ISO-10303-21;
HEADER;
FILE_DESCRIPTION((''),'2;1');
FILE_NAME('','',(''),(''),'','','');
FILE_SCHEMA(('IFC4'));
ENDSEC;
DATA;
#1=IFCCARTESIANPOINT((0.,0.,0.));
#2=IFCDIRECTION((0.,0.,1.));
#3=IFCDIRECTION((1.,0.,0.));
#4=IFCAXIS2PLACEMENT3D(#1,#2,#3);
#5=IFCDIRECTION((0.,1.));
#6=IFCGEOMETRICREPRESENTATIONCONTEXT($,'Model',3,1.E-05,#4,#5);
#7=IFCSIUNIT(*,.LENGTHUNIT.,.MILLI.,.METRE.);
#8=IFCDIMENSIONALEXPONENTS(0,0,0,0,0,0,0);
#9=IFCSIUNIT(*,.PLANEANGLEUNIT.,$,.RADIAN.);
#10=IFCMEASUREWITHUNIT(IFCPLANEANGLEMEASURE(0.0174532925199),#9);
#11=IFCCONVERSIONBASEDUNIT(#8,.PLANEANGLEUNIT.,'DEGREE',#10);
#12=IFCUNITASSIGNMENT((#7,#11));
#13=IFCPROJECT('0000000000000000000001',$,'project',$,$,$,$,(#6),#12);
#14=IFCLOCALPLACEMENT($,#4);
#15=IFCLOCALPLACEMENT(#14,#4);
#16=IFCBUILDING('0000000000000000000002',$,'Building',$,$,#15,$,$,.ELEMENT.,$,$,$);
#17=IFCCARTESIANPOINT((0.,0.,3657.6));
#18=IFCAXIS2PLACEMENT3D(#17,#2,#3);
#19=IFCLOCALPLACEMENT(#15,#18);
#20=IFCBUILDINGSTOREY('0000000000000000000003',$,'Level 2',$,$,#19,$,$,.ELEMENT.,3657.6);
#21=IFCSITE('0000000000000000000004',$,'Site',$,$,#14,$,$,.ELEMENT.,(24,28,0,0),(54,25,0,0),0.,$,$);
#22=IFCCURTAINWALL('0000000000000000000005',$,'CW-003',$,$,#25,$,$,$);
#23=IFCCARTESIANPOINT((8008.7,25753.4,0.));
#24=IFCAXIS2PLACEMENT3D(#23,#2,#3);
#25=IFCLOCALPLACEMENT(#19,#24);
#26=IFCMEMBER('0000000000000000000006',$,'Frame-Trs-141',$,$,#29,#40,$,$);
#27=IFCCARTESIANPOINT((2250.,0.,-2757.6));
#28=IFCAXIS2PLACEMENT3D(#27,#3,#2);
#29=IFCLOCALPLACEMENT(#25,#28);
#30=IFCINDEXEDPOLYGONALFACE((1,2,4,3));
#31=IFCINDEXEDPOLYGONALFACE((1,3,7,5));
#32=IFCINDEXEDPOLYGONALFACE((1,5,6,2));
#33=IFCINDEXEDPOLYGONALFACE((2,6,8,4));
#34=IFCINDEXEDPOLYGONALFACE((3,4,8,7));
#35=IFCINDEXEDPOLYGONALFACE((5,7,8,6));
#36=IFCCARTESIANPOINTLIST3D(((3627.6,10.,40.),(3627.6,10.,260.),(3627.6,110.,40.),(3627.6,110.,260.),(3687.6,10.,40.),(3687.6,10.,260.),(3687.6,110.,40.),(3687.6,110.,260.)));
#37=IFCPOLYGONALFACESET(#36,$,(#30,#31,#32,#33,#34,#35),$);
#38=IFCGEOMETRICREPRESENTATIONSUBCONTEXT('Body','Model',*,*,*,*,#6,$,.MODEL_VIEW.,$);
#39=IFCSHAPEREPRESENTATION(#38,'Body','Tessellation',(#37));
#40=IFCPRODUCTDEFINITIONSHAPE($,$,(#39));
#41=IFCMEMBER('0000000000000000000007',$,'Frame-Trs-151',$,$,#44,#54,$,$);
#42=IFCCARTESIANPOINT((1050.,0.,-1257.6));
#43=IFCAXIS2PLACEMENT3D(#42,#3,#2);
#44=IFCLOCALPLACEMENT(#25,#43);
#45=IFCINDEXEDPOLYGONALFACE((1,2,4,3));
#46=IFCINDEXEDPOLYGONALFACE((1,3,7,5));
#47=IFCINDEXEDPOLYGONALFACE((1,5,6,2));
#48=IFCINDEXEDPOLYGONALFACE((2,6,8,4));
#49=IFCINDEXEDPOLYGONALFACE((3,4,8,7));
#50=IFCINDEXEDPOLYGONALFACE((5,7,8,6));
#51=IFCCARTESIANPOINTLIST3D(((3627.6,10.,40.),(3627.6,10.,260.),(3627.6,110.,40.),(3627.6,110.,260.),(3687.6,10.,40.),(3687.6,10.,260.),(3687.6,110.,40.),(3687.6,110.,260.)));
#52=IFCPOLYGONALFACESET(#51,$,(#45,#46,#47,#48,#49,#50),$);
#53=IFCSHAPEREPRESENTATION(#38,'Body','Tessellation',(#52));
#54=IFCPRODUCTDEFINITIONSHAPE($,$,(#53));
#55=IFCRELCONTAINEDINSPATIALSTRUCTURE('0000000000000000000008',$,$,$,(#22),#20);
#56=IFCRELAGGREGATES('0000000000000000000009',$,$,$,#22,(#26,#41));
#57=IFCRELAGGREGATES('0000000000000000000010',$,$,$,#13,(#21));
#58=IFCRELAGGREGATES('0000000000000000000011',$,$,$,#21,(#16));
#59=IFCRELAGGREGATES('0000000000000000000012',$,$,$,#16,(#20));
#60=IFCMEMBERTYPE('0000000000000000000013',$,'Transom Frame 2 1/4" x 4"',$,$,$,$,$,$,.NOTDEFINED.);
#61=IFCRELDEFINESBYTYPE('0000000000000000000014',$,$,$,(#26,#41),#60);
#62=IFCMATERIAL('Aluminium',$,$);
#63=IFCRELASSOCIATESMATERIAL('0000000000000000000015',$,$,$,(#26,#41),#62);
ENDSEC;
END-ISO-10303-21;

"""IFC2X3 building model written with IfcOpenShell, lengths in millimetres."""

from ifc_helpers import new_model, entity, si_unit, converted_unit, direction, frame, origin_with_axes, place, context, subcontext, project, spatial, polyline, outline, extrude, material, type_object, element, aggregate, save


model = new_model("IFC2X3")

# Units and contexts
model_context = context("Model", 3, precision=1e-05, world=origin_with_axes(), true_north=direction((0.0, 1.0)))
body_context = subcontext(model_context, "Body", "Model", "MODEL_VIEW")
ifc_project = project(units=[si_unit("LENGTHUNIT", "METRE", prefix="MILLI"), converted_unit("PLANEANGLEUNIT", "DEGREE", entity("IfcPlaneAngleMeasure", 0.0174532925199), si_unit("PLANEANGLEUNIT", "RADIAN"), dimensions=[0, 0, 0, 0, 0, 0, 0])], contexts=[model_context])

# Site, building, storey
site_placement = place(None, origin_with_axes())
site = spatial("IfcSite", under=ifc_project, at=site_placement, Name="Site", CompositionType="ELEMENT", RefLatitude=(24, 28, 0, 0), RefLongitude=(54, 25, 0, 0), RefElevation=0.0)
building_placement = place(site_placement, origin_with_axes())
building = spatial("IfcBuilding", under=site, at=building_placement, Name="Building", CompositionType="ELEMENT")
storey_placement = place(building_placement, frame((0.0, 0.0, 3657.6), z_axis=(0.0, 0.0, 1.0), x_axis=(1.0, 0.0, 0.0)))
storey = spatial("IfcBuildingStorey", under=building, at=storey_placement, Name="Level 2", CompositionType="ELEMENT", Elevation=3657.6)

# Curtain wall, members
curtain_wall_placement = place(storey_placement, frame((8008.7, 25753.4, 0.0), z_axis=(0.0, 0.0, 1.0), x_axis=(1.0, 0.0, 0.0)))
curtain_wall = element("IfcCurtainWall", 1, at=curtain_wall_placement, inside=storey, Name="CW-003")
ifc_material_1 = material(Name="Aluminium")
member_type_1 = type_object("IfcMemberType", Name="Transom Frame 2 1/4\" x 4\"", PredefinedType="NOTDEFINED")
member_1_placement = place(curtain_wall_placement, frame((2250.0, 0.0, -2757.6), z_axis=(1.0, 0.0, 0.0), x_axis=(0.0, 0.0, 1.0)))
member_1 = element("IfcMember", 2, at=member_1_placement, type_object=member_type_1, material=ifc_material_1, Name="Frame-Trs-141", context=body_context, shape_type="SweptSolid", body=[
    extrude(outline(polyline([(110.0, -3687.6), (110.0, -3627.6), (10.0, -3627.6), (10.0, -3687.6), (110.0, -3687.6)])), frame((0.0, 0.0, 40.0), z_axis=(0.0, 0.0, 1.0), x_axis=(0.0, 1.0, 0.0)), (0.0, 0.0, 1.0), 220.0),
])
member_2_placement = place(curtain_wall_placement, frame((1050.0, 0.0, -1257.6), z_axis=(1.0, 0.0, 0.0), x_axis=(0.0, 0.0, 1.0)))
member_2 = element("IfcMember", 3, at=member_2_placement, type_object=member_type_1, material=ifc_material_1, Name="Frame-Trs-151", context=body_context, shape_type="SweptSolid", body=[
    extrude(outline(polyline([(110.0, -3687.6), (110.0, -3627.6), (10.0, -3627.6), (10.0, -3687.6), (110.0, -3687.6)])), frame((0.0, 0.0, 40.0), z_axis=(0.0, 0.0, 1.0), x_axis=(0.0, 1.0, 0.0)), (0.0, 0.0, 1.0), 220.0),
])
aggregate(curtain_wall, [member_1, member_2])

save(model, "model.ifc")
